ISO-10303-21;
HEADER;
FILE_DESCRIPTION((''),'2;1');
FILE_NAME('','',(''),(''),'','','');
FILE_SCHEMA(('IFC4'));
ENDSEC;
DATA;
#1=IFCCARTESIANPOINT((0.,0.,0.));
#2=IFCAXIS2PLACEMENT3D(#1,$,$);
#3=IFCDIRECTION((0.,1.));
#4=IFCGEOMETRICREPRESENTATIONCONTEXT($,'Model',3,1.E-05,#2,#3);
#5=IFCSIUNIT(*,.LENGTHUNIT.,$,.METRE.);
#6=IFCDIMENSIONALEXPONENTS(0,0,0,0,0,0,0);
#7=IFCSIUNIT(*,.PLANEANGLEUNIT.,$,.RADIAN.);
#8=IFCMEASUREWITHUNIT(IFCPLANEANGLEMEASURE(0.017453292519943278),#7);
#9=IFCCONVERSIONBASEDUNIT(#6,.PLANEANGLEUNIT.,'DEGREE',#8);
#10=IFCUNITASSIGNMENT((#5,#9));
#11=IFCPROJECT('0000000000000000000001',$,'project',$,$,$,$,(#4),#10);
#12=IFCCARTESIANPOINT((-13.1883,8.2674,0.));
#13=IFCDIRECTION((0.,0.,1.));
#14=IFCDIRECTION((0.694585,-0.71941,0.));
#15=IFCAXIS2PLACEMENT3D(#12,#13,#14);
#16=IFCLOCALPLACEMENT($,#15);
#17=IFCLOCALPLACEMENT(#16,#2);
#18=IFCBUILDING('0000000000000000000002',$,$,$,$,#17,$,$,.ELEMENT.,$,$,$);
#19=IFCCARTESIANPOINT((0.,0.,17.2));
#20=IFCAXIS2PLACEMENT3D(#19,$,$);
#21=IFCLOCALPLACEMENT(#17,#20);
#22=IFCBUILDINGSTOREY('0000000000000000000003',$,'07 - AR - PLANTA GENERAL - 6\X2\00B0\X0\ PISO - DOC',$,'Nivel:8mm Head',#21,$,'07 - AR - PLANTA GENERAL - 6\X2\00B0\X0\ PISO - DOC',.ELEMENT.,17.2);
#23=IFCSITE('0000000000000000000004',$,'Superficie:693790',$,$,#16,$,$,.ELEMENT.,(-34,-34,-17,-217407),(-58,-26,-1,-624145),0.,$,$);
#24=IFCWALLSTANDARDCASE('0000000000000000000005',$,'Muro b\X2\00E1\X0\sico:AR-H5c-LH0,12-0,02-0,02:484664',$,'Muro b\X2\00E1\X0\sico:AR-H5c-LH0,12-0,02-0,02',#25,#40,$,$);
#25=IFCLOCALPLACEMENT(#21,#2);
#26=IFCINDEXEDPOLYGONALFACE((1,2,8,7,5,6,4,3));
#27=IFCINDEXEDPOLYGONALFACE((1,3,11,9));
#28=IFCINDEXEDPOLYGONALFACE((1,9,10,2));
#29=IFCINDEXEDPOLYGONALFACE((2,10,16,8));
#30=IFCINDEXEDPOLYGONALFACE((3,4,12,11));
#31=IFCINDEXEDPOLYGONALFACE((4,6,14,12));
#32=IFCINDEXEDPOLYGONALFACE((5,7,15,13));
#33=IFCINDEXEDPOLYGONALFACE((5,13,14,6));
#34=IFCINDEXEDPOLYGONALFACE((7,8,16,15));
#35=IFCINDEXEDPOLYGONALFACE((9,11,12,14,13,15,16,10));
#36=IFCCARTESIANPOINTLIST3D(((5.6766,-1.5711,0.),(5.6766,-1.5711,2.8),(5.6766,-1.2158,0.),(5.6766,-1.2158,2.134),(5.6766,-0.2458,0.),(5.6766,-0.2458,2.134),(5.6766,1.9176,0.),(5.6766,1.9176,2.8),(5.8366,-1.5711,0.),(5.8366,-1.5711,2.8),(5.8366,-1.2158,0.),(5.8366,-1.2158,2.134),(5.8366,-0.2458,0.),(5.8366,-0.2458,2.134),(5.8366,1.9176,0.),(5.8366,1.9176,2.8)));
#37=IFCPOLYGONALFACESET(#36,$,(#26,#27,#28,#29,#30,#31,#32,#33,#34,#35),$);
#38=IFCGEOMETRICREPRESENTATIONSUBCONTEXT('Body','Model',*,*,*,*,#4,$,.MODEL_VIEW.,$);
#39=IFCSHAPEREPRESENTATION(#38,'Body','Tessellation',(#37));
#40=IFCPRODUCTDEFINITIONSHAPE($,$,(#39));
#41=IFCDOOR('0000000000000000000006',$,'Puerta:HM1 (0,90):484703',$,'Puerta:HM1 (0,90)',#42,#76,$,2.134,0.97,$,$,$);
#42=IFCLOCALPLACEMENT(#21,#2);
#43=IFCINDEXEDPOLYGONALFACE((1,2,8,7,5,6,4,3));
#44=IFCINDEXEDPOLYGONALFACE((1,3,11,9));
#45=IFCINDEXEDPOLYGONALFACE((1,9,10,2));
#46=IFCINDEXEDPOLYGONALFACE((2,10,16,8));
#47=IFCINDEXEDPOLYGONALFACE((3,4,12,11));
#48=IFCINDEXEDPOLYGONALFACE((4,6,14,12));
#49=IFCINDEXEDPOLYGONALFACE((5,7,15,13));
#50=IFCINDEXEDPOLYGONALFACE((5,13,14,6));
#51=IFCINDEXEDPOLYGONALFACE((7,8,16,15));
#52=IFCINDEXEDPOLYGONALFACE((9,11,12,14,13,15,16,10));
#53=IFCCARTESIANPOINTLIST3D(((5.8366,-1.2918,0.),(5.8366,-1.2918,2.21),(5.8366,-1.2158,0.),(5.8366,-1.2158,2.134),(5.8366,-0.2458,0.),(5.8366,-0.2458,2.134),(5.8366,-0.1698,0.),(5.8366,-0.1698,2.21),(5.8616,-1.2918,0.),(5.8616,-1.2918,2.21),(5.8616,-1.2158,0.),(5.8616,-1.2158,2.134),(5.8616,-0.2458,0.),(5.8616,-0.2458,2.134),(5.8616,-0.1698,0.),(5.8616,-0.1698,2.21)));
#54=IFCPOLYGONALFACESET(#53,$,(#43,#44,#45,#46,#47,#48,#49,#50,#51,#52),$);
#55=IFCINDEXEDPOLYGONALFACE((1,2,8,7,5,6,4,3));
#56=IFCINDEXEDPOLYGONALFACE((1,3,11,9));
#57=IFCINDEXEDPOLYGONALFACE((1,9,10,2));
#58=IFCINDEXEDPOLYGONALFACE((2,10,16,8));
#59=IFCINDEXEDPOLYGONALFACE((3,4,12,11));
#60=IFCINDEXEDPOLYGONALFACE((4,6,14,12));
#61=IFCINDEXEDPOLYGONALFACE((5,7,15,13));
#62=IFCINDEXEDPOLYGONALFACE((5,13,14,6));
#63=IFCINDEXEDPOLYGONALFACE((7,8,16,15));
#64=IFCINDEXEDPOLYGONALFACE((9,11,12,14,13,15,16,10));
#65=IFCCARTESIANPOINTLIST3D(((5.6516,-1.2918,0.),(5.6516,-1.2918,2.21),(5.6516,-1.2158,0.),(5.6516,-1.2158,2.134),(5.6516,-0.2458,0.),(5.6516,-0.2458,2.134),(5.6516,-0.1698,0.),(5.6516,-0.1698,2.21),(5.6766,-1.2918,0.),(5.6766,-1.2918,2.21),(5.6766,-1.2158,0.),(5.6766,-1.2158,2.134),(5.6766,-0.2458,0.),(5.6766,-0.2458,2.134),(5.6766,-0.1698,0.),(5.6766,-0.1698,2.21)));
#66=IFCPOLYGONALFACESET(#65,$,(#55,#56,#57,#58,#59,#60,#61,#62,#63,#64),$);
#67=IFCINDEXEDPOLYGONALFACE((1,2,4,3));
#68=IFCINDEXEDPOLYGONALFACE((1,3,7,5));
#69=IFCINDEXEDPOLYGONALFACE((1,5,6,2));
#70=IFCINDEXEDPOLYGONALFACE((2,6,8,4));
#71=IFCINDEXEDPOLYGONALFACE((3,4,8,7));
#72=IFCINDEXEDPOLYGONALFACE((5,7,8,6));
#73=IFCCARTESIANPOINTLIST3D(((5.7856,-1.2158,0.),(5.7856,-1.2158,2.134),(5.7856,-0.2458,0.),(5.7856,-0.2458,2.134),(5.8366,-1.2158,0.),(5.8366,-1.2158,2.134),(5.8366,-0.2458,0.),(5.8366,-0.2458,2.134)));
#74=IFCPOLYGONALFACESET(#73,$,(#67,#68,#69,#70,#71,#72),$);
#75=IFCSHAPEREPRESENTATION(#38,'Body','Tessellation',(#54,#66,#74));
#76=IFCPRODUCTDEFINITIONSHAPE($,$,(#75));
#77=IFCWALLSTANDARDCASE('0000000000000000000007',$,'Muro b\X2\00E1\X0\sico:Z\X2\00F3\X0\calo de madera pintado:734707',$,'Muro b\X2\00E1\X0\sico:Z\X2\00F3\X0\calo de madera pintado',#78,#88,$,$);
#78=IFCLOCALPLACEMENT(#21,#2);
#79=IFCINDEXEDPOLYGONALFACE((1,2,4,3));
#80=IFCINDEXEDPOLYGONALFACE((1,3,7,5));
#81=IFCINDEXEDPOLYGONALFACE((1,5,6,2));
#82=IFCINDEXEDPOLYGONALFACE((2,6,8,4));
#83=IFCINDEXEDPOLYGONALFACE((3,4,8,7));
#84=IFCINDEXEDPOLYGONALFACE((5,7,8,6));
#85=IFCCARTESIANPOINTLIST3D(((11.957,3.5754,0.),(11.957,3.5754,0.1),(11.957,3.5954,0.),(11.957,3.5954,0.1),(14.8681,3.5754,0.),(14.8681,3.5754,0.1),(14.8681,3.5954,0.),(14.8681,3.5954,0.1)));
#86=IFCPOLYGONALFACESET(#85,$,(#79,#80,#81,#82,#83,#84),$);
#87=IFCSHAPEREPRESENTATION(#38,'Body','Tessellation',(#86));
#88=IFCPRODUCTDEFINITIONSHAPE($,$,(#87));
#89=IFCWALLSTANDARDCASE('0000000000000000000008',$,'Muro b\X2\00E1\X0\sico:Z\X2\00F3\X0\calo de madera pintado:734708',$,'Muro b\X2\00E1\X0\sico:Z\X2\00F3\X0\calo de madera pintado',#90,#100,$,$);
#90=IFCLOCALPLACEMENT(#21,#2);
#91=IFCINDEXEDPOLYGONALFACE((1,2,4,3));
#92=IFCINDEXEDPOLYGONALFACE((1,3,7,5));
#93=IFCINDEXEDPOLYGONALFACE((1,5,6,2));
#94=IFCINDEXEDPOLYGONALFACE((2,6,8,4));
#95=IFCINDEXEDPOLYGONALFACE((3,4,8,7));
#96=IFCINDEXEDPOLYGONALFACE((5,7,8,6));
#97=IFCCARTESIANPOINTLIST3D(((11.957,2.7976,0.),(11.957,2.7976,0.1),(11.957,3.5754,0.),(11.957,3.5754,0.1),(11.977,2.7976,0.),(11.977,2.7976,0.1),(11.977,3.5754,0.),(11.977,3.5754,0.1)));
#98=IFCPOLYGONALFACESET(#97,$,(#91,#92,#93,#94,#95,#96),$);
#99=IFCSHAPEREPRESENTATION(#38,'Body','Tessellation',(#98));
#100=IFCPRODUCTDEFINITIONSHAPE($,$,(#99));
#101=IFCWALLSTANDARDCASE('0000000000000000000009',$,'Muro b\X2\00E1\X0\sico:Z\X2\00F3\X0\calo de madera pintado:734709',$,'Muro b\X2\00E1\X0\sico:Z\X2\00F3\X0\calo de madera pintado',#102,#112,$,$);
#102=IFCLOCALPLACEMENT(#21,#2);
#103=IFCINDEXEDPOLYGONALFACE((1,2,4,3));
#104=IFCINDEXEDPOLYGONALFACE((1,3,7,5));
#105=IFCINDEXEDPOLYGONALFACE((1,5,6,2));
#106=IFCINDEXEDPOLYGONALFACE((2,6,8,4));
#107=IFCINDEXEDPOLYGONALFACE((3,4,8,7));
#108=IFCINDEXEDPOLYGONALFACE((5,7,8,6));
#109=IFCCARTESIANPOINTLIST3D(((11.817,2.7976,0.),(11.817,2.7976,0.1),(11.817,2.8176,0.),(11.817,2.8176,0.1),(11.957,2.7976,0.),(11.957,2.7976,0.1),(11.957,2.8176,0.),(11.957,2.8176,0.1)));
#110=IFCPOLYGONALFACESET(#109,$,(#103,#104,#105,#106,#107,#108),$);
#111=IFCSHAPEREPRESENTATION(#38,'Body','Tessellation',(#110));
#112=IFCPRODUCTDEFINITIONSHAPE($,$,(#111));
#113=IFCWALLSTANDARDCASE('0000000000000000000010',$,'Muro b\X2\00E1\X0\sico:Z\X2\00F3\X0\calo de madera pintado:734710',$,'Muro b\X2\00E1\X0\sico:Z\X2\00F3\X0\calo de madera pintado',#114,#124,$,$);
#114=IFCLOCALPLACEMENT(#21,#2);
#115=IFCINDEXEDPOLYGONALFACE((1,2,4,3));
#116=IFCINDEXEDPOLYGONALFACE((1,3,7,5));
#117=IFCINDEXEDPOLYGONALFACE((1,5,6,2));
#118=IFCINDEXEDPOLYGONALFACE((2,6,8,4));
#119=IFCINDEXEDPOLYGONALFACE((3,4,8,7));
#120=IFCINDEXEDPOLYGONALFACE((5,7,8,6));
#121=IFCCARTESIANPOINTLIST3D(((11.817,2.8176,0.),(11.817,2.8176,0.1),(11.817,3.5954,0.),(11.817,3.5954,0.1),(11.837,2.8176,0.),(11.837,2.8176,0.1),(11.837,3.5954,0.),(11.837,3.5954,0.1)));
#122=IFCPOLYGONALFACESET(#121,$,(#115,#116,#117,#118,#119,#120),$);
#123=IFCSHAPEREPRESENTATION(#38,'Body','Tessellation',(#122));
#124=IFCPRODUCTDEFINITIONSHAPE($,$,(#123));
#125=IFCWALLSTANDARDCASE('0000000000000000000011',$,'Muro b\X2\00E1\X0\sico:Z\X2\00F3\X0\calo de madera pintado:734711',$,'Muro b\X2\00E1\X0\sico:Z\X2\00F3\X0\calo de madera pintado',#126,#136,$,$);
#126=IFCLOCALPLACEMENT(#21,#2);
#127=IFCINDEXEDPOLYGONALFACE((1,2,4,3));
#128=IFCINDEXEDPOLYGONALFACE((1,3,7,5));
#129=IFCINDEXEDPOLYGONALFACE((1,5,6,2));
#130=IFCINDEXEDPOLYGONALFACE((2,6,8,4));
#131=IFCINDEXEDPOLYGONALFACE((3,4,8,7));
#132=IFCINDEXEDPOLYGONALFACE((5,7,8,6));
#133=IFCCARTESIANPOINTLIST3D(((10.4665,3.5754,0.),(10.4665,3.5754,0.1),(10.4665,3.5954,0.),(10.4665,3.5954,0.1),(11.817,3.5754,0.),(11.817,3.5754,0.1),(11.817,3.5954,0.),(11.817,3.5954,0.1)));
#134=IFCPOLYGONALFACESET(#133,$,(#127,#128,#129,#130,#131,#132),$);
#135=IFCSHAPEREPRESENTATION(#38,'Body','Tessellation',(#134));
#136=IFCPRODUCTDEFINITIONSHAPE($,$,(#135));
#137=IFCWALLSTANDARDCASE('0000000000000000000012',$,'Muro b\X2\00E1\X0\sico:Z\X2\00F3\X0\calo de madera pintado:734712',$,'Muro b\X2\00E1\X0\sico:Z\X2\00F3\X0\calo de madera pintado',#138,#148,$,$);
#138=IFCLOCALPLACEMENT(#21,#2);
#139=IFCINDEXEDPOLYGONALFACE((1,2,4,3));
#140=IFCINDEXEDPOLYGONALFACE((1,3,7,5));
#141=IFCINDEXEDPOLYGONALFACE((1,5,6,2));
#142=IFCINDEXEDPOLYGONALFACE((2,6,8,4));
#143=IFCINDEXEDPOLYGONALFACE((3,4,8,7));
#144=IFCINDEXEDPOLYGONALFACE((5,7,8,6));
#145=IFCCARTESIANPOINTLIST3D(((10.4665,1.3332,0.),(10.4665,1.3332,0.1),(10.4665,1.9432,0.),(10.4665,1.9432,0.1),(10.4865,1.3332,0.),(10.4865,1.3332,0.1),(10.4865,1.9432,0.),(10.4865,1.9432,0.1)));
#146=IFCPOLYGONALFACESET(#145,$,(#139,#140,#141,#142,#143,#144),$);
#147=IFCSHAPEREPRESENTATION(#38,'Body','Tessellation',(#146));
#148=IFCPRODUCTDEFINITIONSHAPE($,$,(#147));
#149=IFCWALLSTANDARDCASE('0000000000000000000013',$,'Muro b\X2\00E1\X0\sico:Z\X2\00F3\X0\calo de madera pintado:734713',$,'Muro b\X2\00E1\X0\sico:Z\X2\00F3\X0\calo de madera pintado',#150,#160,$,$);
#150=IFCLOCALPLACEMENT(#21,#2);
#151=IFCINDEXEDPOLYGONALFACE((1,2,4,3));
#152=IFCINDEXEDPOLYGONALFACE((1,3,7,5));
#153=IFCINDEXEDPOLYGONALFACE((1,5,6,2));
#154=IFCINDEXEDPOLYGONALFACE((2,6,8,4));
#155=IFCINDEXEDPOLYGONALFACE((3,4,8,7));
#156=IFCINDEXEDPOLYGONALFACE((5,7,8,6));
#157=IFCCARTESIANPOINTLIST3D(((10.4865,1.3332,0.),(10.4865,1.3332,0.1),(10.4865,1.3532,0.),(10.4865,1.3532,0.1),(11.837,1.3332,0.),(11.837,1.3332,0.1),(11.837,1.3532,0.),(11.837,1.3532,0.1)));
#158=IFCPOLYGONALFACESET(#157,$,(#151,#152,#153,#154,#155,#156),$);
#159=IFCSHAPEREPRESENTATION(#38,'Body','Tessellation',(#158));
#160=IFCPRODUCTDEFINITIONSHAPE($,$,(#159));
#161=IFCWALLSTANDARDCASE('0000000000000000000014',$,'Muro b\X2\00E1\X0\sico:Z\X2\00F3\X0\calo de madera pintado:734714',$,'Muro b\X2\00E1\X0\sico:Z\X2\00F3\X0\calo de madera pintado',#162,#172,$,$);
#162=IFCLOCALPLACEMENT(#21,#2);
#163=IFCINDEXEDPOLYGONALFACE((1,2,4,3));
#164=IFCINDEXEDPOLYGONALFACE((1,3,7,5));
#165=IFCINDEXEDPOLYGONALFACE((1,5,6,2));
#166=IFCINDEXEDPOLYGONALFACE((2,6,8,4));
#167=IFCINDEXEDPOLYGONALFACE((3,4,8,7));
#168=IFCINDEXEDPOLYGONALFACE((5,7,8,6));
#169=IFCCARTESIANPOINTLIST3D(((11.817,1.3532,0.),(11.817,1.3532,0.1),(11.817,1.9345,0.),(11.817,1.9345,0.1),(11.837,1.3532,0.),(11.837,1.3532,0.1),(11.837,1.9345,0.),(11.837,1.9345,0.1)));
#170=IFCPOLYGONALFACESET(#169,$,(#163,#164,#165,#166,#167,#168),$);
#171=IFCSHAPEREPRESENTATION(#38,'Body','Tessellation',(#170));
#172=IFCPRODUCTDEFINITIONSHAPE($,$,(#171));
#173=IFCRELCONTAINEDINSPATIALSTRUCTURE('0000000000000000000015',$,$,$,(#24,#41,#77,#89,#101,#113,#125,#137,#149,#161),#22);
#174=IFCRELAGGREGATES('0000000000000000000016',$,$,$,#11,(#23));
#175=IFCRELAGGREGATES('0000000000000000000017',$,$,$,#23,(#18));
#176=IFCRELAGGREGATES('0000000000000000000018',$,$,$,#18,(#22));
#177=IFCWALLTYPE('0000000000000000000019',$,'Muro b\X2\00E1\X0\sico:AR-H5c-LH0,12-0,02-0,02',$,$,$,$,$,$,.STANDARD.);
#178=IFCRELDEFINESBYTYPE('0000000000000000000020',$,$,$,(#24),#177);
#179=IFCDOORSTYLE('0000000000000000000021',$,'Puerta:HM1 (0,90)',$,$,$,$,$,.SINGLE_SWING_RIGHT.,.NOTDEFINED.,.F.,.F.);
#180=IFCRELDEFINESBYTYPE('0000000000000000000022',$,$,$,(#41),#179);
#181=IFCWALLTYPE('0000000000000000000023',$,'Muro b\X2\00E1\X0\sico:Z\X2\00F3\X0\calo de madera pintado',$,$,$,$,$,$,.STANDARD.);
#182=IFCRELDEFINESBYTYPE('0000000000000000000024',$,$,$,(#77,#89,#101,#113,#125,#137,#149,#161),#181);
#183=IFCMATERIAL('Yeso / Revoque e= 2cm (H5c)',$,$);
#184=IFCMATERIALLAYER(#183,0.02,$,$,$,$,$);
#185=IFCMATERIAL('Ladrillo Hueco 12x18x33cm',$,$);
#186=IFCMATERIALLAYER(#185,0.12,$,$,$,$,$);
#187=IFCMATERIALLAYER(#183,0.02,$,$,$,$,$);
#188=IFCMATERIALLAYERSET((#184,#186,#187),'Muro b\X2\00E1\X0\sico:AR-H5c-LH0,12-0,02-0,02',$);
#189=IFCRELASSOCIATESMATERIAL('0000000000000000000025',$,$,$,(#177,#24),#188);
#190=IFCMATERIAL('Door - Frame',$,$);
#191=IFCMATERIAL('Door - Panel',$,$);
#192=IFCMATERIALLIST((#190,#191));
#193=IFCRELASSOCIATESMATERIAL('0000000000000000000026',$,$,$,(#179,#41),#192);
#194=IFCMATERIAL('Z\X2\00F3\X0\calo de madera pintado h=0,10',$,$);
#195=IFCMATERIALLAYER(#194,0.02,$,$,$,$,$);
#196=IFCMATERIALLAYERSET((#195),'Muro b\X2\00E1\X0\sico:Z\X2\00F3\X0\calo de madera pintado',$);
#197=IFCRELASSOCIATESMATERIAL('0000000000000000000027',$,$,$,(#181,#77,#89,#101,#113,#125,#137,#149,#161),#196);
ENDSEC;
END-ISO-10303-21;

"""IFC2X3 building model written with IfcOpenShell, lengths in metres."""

from ifc_helpers import new_model, entity, si_unit, converted_unit, direction, frame, frame_2d, origin, place, context, subcontext, project, spatial, polyline, rectangle, outline, extrude, source, transform, mapped, material, material_list, layer, layer_set, layer_usage, type_object, type_shapes, element, fill, save


model = new_model("IFC2X3")

# Units and contexts
model_context = context("Model", 3, precision=1e-05, world=origin(), true_north=direction((0.0, 1.0)))
body_context = subcontext(model_context, "Body", "Model", "MODEL_VIEW")
ifc_project = project(units=[si_unit("LENGTHUNIT", "METRE"), converted_unit("PLANEANGLEUNIT", "DEGREE", entity("IfcPlaneAngleMeasure", 0.017453292519943278), si_unit("PLANEANGLEUNIT", "RADIAN"), dimensions=[0, 0, 0, 0, 0, 0, 0])], contexts=[model_context])

# Site, building, storey
site_placement = place(None, frame((-13.1883, 8.2674, 0.0), z_axis=(0.0, 0.0, 1.0), x_axis=(0.694585, -0.71941, 0.0)))
site = spatial("IfcSite", under=ifc_project, at=site_placement, Name="Superficie:693790", CompositionType="ELEMENT", RefLatitude=(-34, -34, -17, -217407), RefLongitude=(-58, -26, -1, -624145), RefElevation=0.0)
building_placement = place(site_placement, origin())
building = spatial("IfcBuilding", under=site, at=building_placement, CompositionType="ELEMENT")
storey_placement = place(building_placement, frame((0.0, 0.0, 17.2)))
storey = spatial("IfcBuildingStorey", under=building, at=storey_placement, Name="07 - AR - PLANTA GENERAL - 6° PISO - DOC", ObjectType="Nivel:8mm Head", LongName="07 - AR - PLANTA GENERAL - 6° PISO - DOC", CompositionType="ELEMENT", Elevation=17.2)

# Shared definitions
ifc_material_1 = material(Name="Door - Frame")
ifc_material_2 = material(Name="Door - Panel")
ifc_material_list = material_list([ifc_material_1, ifc_material_2])

# Wall, opening, door
ifc_material_3 = material(Name="Yeso / Revoque e= 2cm (H5c)")
ifc_layer_1 = layer(ifc_material_3, 0.02)
ifc_material_4 = material(Name="Ladrillo Hueco 12x18x33cm")
ifc_layer_2 = layer(ifc_material_4, 0.12)
ifc_layer_3 = layer(ifc_material_3, 0.02)
ifc_layer_set_1 = layer_set([ifc_layer_1, ifc_layer_2, ifc_layer_3], Name="Muro básico:AR-H5c-LH0,12-0,02-0,02")
ifc_layer_usage_1 = layer_usage(ifc_layer_set_1, "AXIS2", "NEGATIVE", 0.08)
wall_type_1 = type_object("IfcWallType", Name="Muro básico:AR-H5c-LH0,12-0,02-0,02", PredefinedType="STANDARD", material=ifc_layer_set_1)
wall_1_placement = place(storey_placement, frame((5.7566, 1.9176, 0.0), z_axis=(0.0, 0.0, 1.0), x_axis=(0.0, -1.0, 0.0)))
wall_1 = element("IfcWallStandardCase", 1, at=wall_1_placement, inside=storey, type_object=wall_type_1, material=ifc_layer_usage_1, Name="Muro básico:AR-H5c-LH0,12-0,02-0,02:484664", ObjectType="Muro básico:AR-H5c-LH0,12-0,02-0,02", context=body_context, shape_type="SweptSolid", body=[
    extrude(rectangle(XDim=3.4887, YDim=0.16, at=frame_2d((1.7443, 0.0), x_axis=(-1.0, 0.0))), origin(), (0.0, 0.0, 1.0), 2.8),
])
opening_1_placement = place(wall_1_placement, frame((2.1634, -0.08, 0.0)))
opening_1 = element("IfcOpeningElement", 2, at=opening_1_placement, cuts=wall_1, ObjectType="Opening", context=body_context, shape_type="SweptSolid", body=[
    extrude(rectangle(XDim=0.97, YDim=2.134, at=frame_2d((1.067, 0.485), x_axis=(0.0, 1.0))), frame((0.0, 0.0, 0.0), z_axis=(0.0, 1.0, 0.0), x_axis=(0.0, 0.0, 1.0)), (0.0, 0.0, 1.0), 0.16),
])
door_style_1 = type_object("IfcDoorStyle", Name="Puerta:HM1 (0,90)", ConstructionType="NOTDEFINED", OperationType="SINGLE_SWING_RIGHT", ParameterTakesPrecedence=False, Sizeable=False, material=ifc_material_list)
shared_shape_1 = source(origin(), body_context, "Body", "SweptSolid", [
    extrude(outline(polyline([(-0.561, -1.124), (0.561, -1.124), (0.561, 1.086), (0.485, 1.086), (0.485, -1.048), (-0.485, -1.048), (-0.485, 1.086), (-0.561, 1.086), (-0.561, -1.124)])), frame((0.485, 0.16, 1.086), z_axis=(0.0, 1.0, 0.0), x_axis=(1.0, 0.0, 0.0)), (0.0, 0.0, 1.0), 0.025),
    extrude(outline(polyline([(-1.124, -0.561), (1.086, -0.561), (1.086, -0.485), (-1.048, -0.485), (-1.048, 0.485), (1.086, 0.485), (1.086, 0.561), (-1.124, 0.561), (-1.124, -0.561)])), frame((0.485, -0.025, 1.086), z_axis=(0.0, 1.0, 0.0), x_axis=(0.0, 0.0, -1.0)), (0.0, 0.0, 1.0), 0.025),
    extrude(rectangle(XDim=0.051, YDim=0.97, at=frame_2d((0.0, 0.0), x_axis=(1.0, 0.0))), frame((0.485, 0.1345, 0.0), z_axis=(0.0, 0.0, 1.0), x_axis=(0.0, 1.0, 0.0)), (0.0, 0.0, 1.0), 2.134),
])
type_shapes(door_style_1, [shared_shape_1])
door_1_placement = place(opening_1_placement, origin())
door_1 = element("IfcDoor", 3, at=door_1_placement, inside=storey, type_object=door_style_1, material=ifc_material_list, Name="Puerta:HM1 (0,90):484703", ObjectType="Puerta:HM1 (0,90)", OverallHeight=2.134, OverallWidth=0.97, context=body_context, shape_type="MappedRepresentation", body=[
    mapped(shared_shape_1, transform((0.0, 0.0, 0.0), scale=1.0)),
])
fill(opening_1, door_1)

# Walls
ifc_material_5 = material(Name="Zócalo de madera pintado h=0,10")
ifc_layer_4 = layer(ifc_material_5, 0.02)
ifc_layer_set_2 = layer_set([ifc_layer_4], Name="Muro básico:Zócalo de madera pintado")
ifc_layer_usage_2 = layer_usage(ifc_layer_set_2, "AXIS2", "NEGATIVE", 0.01)
wall_type_2 = type_object("IfcWallType", Name="Muro básico:Zócalo de madera pintado", PredefinedType="STANDARD", material=ifc_layer_set_2)
wall_2_placement = place(storey_placement, frame((11.957, 3.5854, 0.0)))
element("IfcWallStandardCase", 4, at=wall_2_placement, inside=storey, type_object=wall_type_2, material=ifc_layer_usage_2, Name="Muro básico:Zócalo de madera pintado:734707", ObjectType="Muro básico:Zócalo de madera pintado", context=body_context, shape_type="SweptSolid", body=[
    extrude(rectangle(XDim=2.911, YDim=0.02, at=frame_2d((1.4555, 0.0), x_axis=(-1.0, 0.0))), origin(), (0.0, 0.0, 1.0), 0.1),
])
ifc_layer_usage_3 = layer_usage(ifc_layer_set_2, "AXIS2", "NEGATIVE", 0.01)
wall_3_placement = place(storey_placement, frame((11.967, 2.7976, 0.0), z_axis=(0.0, 0.0, 1.0), x_axis=(0.0, 1.0, 0.0)))
element("IfcWallStandardCase", 5, at=wall_3_placement, inside=storey, type_object=wall_type_2, material=ifc_layer_usage_3, Name="Muro básico:Zócalo de madera pintado:734708", ObjectType="Muro básico:Zócalo de madera pintado", context=body_context, shape_type="SweptSolid", body=[
    extrude(rectangle(XDim=0.7779, YDim=0.02, at=frame_2d((0.3889, 0.0), x_axis=(-1.0, 0.0))), origin(), (0.0, 0.0, 1.0), 0.1),
])
ifc_layer_usage_4 = layer_usage(ifc_layer_set_2, "AXIS2", "NEGATIVE", 0.01)
wall_4_placement = place(storey_placement, frame((11.817, 2.8076, 0.0)))
element("IfcWallStandardCase", 6, at=wall_4_placement, inside=storey, type_object=wall_type_2, material=ifc_layer_usage_4, Name="Muro básico:Zócalo de madera pintado:734709", ObjectType="Muro básico:Zócalo de madera pintado", context=body_context, shape_type="SweptSolid", body=[
    extrude(rectangle(XDim=0.14, YDim=0.02, at=frame_2d((0.07, 0.0), x_axis=(-1.0, 0.0))), origin(), (0.0, 0.0, 1.0), 0.1),
])
ifc_layer_usage_5 = layer_usage(ifc_layer_set_2, "AXIS2", "NEGATIVE", 0.01)
wall_5_placement = place(storey_placement, frame((11.827, 3.5954, 0.0), z_axis=(0.0, 0.0, 1.0), x_axis=(0.0, -1.0, 0.0)))
element("IfcWallStandardCase", 7, at=wall_5_placement, inside=storey, type_object=wall_type_2, material=ifc_layer_usage_5, Name="Muro básico:Zócalo de madera pintado:734710", ObjectType="Muro básico:Zócalo de madera pintado", context=body_context, shape_type="SweptSolid", body=[
    extrude(rectangle(XDim=0.7779, YDim=0.02, at=frame_2d((0.3889, 0.0), x_axis=(-1.0, 0.0))), origin(), (0.0, 0.0, 1.0), 0.1),
])
ifc_layer_usage_6 = layer_usage(ifc_layer_set_2, "AXIS2", "NEGATIVE", 0.01)
wall_6_placement = place(storey_placement, frame((10.4665, 3.5854, 0.0)))
element("IfcWallStandardCase", 8, at=wall_6_placement, inside=storey, type_object=wall_type_2, material=ifc_layer_usage_6, Name="Muro básico:Zócalo de madera pintado:734711", ObjectType="Muro básico:Zócalo de madera pintado", context=body_context, shape_type="SweptSolid", body=[
    extrude(rectangle(XDim=1.3505, YDim=0.02, at=frame_2d((0.6753, 0.0), x_axis=(-1.0, 0.0))), origin(), (0.0, 0.0, 1.0), 0.1),
])
ifc_layer_usage_7 = layer_usage(ifc_layer_set_2, "AXIS2", "NEGATIVE", 0.01)
wall_7_placement = place(storey_placement, frame((10.4765, 1.3332, 0.0), z_axis=(0.0, 0.0, 1.0), x_axis=(0.0, 1.0, 0.0)))
element("IfcWallStandardCase", 9, at=wall_7_placement, inside=storey, type_object=wall_type_2, material=ifc_layer_usage_7, Name="Muro básico:Zócalo de madera pintado:734712", ObjectType="Muro básico:Zócalo de madera pintado", context=body_context, shape_type="SweptSolid", body=[
    extrude(rectangle(XDim=0.61, YDim=0.02, at=frame_2d((0.305, 0.0), x_axis=(-1.0, 0.0))), origin(), (0.0, 0.0, 1.0), 0.1),
])
ifc_layer_usage_8 = layer_usage(ifc_layer_set_2, "AXIS2", "NEGATIVE", 0.01)
wall_8_placement = place(storey_placement, frame((11.837, 1.3432, 0.0), z_axis=(0.0, 0.0, 1.0), x_axis=(-1.0, 0.0, 0.0)))
element("IfcWallStandardCase", 10, at=wall_8_placement, inside=storey, type_object=wall_type_2, material=ifc_layer_usage_8, Name="Muro básico:Zócalo de madera pintado:734713", ObjectType="Muro básico:Zócalo de madera pintado", context=body_context, shape_type="SweptSolid", body=[
    extrude(rectangle(XDim=1.3505, YDim=0.02, at=frame_2d((0.6753, 0.0), x_axis=(-1.0, 0.0))), origin(), (0.0, 0.0, 1.0), 0.1),
])
ifc_layer_usage_9 = layer_usage(ifc_layer_set_2, "AXIS2", "NEGATIVE", 0.01)
wall_9_placement = place(storey_placement, frame((11.827, 1.9345, 0.0), z_axis=(0.0, 0.0, 1.0), x_axis=(0.0, -1.0, 0.0)))
element("IfcWallStandardCase", 11, at=wall_9_placement, inside=storey, type_object=wall_type_2, material=ifc_layer_usage_9, Name="Muro básico:Zócalo de madera pintado:734714", ObjectType="Muro básico:Zócalo de madera pintado", context=body_context, shape_type="SweptSolid", body=[
    extrude(rectangle(XDim=0.5814, YDim=0.02, at=frame_2d((0.2907, 0.0), x_axis=(-1.0, 0.0))), origin(), (0.0, 0.0, 1.0), 0.1),
])

save(model, "model.ifc")
